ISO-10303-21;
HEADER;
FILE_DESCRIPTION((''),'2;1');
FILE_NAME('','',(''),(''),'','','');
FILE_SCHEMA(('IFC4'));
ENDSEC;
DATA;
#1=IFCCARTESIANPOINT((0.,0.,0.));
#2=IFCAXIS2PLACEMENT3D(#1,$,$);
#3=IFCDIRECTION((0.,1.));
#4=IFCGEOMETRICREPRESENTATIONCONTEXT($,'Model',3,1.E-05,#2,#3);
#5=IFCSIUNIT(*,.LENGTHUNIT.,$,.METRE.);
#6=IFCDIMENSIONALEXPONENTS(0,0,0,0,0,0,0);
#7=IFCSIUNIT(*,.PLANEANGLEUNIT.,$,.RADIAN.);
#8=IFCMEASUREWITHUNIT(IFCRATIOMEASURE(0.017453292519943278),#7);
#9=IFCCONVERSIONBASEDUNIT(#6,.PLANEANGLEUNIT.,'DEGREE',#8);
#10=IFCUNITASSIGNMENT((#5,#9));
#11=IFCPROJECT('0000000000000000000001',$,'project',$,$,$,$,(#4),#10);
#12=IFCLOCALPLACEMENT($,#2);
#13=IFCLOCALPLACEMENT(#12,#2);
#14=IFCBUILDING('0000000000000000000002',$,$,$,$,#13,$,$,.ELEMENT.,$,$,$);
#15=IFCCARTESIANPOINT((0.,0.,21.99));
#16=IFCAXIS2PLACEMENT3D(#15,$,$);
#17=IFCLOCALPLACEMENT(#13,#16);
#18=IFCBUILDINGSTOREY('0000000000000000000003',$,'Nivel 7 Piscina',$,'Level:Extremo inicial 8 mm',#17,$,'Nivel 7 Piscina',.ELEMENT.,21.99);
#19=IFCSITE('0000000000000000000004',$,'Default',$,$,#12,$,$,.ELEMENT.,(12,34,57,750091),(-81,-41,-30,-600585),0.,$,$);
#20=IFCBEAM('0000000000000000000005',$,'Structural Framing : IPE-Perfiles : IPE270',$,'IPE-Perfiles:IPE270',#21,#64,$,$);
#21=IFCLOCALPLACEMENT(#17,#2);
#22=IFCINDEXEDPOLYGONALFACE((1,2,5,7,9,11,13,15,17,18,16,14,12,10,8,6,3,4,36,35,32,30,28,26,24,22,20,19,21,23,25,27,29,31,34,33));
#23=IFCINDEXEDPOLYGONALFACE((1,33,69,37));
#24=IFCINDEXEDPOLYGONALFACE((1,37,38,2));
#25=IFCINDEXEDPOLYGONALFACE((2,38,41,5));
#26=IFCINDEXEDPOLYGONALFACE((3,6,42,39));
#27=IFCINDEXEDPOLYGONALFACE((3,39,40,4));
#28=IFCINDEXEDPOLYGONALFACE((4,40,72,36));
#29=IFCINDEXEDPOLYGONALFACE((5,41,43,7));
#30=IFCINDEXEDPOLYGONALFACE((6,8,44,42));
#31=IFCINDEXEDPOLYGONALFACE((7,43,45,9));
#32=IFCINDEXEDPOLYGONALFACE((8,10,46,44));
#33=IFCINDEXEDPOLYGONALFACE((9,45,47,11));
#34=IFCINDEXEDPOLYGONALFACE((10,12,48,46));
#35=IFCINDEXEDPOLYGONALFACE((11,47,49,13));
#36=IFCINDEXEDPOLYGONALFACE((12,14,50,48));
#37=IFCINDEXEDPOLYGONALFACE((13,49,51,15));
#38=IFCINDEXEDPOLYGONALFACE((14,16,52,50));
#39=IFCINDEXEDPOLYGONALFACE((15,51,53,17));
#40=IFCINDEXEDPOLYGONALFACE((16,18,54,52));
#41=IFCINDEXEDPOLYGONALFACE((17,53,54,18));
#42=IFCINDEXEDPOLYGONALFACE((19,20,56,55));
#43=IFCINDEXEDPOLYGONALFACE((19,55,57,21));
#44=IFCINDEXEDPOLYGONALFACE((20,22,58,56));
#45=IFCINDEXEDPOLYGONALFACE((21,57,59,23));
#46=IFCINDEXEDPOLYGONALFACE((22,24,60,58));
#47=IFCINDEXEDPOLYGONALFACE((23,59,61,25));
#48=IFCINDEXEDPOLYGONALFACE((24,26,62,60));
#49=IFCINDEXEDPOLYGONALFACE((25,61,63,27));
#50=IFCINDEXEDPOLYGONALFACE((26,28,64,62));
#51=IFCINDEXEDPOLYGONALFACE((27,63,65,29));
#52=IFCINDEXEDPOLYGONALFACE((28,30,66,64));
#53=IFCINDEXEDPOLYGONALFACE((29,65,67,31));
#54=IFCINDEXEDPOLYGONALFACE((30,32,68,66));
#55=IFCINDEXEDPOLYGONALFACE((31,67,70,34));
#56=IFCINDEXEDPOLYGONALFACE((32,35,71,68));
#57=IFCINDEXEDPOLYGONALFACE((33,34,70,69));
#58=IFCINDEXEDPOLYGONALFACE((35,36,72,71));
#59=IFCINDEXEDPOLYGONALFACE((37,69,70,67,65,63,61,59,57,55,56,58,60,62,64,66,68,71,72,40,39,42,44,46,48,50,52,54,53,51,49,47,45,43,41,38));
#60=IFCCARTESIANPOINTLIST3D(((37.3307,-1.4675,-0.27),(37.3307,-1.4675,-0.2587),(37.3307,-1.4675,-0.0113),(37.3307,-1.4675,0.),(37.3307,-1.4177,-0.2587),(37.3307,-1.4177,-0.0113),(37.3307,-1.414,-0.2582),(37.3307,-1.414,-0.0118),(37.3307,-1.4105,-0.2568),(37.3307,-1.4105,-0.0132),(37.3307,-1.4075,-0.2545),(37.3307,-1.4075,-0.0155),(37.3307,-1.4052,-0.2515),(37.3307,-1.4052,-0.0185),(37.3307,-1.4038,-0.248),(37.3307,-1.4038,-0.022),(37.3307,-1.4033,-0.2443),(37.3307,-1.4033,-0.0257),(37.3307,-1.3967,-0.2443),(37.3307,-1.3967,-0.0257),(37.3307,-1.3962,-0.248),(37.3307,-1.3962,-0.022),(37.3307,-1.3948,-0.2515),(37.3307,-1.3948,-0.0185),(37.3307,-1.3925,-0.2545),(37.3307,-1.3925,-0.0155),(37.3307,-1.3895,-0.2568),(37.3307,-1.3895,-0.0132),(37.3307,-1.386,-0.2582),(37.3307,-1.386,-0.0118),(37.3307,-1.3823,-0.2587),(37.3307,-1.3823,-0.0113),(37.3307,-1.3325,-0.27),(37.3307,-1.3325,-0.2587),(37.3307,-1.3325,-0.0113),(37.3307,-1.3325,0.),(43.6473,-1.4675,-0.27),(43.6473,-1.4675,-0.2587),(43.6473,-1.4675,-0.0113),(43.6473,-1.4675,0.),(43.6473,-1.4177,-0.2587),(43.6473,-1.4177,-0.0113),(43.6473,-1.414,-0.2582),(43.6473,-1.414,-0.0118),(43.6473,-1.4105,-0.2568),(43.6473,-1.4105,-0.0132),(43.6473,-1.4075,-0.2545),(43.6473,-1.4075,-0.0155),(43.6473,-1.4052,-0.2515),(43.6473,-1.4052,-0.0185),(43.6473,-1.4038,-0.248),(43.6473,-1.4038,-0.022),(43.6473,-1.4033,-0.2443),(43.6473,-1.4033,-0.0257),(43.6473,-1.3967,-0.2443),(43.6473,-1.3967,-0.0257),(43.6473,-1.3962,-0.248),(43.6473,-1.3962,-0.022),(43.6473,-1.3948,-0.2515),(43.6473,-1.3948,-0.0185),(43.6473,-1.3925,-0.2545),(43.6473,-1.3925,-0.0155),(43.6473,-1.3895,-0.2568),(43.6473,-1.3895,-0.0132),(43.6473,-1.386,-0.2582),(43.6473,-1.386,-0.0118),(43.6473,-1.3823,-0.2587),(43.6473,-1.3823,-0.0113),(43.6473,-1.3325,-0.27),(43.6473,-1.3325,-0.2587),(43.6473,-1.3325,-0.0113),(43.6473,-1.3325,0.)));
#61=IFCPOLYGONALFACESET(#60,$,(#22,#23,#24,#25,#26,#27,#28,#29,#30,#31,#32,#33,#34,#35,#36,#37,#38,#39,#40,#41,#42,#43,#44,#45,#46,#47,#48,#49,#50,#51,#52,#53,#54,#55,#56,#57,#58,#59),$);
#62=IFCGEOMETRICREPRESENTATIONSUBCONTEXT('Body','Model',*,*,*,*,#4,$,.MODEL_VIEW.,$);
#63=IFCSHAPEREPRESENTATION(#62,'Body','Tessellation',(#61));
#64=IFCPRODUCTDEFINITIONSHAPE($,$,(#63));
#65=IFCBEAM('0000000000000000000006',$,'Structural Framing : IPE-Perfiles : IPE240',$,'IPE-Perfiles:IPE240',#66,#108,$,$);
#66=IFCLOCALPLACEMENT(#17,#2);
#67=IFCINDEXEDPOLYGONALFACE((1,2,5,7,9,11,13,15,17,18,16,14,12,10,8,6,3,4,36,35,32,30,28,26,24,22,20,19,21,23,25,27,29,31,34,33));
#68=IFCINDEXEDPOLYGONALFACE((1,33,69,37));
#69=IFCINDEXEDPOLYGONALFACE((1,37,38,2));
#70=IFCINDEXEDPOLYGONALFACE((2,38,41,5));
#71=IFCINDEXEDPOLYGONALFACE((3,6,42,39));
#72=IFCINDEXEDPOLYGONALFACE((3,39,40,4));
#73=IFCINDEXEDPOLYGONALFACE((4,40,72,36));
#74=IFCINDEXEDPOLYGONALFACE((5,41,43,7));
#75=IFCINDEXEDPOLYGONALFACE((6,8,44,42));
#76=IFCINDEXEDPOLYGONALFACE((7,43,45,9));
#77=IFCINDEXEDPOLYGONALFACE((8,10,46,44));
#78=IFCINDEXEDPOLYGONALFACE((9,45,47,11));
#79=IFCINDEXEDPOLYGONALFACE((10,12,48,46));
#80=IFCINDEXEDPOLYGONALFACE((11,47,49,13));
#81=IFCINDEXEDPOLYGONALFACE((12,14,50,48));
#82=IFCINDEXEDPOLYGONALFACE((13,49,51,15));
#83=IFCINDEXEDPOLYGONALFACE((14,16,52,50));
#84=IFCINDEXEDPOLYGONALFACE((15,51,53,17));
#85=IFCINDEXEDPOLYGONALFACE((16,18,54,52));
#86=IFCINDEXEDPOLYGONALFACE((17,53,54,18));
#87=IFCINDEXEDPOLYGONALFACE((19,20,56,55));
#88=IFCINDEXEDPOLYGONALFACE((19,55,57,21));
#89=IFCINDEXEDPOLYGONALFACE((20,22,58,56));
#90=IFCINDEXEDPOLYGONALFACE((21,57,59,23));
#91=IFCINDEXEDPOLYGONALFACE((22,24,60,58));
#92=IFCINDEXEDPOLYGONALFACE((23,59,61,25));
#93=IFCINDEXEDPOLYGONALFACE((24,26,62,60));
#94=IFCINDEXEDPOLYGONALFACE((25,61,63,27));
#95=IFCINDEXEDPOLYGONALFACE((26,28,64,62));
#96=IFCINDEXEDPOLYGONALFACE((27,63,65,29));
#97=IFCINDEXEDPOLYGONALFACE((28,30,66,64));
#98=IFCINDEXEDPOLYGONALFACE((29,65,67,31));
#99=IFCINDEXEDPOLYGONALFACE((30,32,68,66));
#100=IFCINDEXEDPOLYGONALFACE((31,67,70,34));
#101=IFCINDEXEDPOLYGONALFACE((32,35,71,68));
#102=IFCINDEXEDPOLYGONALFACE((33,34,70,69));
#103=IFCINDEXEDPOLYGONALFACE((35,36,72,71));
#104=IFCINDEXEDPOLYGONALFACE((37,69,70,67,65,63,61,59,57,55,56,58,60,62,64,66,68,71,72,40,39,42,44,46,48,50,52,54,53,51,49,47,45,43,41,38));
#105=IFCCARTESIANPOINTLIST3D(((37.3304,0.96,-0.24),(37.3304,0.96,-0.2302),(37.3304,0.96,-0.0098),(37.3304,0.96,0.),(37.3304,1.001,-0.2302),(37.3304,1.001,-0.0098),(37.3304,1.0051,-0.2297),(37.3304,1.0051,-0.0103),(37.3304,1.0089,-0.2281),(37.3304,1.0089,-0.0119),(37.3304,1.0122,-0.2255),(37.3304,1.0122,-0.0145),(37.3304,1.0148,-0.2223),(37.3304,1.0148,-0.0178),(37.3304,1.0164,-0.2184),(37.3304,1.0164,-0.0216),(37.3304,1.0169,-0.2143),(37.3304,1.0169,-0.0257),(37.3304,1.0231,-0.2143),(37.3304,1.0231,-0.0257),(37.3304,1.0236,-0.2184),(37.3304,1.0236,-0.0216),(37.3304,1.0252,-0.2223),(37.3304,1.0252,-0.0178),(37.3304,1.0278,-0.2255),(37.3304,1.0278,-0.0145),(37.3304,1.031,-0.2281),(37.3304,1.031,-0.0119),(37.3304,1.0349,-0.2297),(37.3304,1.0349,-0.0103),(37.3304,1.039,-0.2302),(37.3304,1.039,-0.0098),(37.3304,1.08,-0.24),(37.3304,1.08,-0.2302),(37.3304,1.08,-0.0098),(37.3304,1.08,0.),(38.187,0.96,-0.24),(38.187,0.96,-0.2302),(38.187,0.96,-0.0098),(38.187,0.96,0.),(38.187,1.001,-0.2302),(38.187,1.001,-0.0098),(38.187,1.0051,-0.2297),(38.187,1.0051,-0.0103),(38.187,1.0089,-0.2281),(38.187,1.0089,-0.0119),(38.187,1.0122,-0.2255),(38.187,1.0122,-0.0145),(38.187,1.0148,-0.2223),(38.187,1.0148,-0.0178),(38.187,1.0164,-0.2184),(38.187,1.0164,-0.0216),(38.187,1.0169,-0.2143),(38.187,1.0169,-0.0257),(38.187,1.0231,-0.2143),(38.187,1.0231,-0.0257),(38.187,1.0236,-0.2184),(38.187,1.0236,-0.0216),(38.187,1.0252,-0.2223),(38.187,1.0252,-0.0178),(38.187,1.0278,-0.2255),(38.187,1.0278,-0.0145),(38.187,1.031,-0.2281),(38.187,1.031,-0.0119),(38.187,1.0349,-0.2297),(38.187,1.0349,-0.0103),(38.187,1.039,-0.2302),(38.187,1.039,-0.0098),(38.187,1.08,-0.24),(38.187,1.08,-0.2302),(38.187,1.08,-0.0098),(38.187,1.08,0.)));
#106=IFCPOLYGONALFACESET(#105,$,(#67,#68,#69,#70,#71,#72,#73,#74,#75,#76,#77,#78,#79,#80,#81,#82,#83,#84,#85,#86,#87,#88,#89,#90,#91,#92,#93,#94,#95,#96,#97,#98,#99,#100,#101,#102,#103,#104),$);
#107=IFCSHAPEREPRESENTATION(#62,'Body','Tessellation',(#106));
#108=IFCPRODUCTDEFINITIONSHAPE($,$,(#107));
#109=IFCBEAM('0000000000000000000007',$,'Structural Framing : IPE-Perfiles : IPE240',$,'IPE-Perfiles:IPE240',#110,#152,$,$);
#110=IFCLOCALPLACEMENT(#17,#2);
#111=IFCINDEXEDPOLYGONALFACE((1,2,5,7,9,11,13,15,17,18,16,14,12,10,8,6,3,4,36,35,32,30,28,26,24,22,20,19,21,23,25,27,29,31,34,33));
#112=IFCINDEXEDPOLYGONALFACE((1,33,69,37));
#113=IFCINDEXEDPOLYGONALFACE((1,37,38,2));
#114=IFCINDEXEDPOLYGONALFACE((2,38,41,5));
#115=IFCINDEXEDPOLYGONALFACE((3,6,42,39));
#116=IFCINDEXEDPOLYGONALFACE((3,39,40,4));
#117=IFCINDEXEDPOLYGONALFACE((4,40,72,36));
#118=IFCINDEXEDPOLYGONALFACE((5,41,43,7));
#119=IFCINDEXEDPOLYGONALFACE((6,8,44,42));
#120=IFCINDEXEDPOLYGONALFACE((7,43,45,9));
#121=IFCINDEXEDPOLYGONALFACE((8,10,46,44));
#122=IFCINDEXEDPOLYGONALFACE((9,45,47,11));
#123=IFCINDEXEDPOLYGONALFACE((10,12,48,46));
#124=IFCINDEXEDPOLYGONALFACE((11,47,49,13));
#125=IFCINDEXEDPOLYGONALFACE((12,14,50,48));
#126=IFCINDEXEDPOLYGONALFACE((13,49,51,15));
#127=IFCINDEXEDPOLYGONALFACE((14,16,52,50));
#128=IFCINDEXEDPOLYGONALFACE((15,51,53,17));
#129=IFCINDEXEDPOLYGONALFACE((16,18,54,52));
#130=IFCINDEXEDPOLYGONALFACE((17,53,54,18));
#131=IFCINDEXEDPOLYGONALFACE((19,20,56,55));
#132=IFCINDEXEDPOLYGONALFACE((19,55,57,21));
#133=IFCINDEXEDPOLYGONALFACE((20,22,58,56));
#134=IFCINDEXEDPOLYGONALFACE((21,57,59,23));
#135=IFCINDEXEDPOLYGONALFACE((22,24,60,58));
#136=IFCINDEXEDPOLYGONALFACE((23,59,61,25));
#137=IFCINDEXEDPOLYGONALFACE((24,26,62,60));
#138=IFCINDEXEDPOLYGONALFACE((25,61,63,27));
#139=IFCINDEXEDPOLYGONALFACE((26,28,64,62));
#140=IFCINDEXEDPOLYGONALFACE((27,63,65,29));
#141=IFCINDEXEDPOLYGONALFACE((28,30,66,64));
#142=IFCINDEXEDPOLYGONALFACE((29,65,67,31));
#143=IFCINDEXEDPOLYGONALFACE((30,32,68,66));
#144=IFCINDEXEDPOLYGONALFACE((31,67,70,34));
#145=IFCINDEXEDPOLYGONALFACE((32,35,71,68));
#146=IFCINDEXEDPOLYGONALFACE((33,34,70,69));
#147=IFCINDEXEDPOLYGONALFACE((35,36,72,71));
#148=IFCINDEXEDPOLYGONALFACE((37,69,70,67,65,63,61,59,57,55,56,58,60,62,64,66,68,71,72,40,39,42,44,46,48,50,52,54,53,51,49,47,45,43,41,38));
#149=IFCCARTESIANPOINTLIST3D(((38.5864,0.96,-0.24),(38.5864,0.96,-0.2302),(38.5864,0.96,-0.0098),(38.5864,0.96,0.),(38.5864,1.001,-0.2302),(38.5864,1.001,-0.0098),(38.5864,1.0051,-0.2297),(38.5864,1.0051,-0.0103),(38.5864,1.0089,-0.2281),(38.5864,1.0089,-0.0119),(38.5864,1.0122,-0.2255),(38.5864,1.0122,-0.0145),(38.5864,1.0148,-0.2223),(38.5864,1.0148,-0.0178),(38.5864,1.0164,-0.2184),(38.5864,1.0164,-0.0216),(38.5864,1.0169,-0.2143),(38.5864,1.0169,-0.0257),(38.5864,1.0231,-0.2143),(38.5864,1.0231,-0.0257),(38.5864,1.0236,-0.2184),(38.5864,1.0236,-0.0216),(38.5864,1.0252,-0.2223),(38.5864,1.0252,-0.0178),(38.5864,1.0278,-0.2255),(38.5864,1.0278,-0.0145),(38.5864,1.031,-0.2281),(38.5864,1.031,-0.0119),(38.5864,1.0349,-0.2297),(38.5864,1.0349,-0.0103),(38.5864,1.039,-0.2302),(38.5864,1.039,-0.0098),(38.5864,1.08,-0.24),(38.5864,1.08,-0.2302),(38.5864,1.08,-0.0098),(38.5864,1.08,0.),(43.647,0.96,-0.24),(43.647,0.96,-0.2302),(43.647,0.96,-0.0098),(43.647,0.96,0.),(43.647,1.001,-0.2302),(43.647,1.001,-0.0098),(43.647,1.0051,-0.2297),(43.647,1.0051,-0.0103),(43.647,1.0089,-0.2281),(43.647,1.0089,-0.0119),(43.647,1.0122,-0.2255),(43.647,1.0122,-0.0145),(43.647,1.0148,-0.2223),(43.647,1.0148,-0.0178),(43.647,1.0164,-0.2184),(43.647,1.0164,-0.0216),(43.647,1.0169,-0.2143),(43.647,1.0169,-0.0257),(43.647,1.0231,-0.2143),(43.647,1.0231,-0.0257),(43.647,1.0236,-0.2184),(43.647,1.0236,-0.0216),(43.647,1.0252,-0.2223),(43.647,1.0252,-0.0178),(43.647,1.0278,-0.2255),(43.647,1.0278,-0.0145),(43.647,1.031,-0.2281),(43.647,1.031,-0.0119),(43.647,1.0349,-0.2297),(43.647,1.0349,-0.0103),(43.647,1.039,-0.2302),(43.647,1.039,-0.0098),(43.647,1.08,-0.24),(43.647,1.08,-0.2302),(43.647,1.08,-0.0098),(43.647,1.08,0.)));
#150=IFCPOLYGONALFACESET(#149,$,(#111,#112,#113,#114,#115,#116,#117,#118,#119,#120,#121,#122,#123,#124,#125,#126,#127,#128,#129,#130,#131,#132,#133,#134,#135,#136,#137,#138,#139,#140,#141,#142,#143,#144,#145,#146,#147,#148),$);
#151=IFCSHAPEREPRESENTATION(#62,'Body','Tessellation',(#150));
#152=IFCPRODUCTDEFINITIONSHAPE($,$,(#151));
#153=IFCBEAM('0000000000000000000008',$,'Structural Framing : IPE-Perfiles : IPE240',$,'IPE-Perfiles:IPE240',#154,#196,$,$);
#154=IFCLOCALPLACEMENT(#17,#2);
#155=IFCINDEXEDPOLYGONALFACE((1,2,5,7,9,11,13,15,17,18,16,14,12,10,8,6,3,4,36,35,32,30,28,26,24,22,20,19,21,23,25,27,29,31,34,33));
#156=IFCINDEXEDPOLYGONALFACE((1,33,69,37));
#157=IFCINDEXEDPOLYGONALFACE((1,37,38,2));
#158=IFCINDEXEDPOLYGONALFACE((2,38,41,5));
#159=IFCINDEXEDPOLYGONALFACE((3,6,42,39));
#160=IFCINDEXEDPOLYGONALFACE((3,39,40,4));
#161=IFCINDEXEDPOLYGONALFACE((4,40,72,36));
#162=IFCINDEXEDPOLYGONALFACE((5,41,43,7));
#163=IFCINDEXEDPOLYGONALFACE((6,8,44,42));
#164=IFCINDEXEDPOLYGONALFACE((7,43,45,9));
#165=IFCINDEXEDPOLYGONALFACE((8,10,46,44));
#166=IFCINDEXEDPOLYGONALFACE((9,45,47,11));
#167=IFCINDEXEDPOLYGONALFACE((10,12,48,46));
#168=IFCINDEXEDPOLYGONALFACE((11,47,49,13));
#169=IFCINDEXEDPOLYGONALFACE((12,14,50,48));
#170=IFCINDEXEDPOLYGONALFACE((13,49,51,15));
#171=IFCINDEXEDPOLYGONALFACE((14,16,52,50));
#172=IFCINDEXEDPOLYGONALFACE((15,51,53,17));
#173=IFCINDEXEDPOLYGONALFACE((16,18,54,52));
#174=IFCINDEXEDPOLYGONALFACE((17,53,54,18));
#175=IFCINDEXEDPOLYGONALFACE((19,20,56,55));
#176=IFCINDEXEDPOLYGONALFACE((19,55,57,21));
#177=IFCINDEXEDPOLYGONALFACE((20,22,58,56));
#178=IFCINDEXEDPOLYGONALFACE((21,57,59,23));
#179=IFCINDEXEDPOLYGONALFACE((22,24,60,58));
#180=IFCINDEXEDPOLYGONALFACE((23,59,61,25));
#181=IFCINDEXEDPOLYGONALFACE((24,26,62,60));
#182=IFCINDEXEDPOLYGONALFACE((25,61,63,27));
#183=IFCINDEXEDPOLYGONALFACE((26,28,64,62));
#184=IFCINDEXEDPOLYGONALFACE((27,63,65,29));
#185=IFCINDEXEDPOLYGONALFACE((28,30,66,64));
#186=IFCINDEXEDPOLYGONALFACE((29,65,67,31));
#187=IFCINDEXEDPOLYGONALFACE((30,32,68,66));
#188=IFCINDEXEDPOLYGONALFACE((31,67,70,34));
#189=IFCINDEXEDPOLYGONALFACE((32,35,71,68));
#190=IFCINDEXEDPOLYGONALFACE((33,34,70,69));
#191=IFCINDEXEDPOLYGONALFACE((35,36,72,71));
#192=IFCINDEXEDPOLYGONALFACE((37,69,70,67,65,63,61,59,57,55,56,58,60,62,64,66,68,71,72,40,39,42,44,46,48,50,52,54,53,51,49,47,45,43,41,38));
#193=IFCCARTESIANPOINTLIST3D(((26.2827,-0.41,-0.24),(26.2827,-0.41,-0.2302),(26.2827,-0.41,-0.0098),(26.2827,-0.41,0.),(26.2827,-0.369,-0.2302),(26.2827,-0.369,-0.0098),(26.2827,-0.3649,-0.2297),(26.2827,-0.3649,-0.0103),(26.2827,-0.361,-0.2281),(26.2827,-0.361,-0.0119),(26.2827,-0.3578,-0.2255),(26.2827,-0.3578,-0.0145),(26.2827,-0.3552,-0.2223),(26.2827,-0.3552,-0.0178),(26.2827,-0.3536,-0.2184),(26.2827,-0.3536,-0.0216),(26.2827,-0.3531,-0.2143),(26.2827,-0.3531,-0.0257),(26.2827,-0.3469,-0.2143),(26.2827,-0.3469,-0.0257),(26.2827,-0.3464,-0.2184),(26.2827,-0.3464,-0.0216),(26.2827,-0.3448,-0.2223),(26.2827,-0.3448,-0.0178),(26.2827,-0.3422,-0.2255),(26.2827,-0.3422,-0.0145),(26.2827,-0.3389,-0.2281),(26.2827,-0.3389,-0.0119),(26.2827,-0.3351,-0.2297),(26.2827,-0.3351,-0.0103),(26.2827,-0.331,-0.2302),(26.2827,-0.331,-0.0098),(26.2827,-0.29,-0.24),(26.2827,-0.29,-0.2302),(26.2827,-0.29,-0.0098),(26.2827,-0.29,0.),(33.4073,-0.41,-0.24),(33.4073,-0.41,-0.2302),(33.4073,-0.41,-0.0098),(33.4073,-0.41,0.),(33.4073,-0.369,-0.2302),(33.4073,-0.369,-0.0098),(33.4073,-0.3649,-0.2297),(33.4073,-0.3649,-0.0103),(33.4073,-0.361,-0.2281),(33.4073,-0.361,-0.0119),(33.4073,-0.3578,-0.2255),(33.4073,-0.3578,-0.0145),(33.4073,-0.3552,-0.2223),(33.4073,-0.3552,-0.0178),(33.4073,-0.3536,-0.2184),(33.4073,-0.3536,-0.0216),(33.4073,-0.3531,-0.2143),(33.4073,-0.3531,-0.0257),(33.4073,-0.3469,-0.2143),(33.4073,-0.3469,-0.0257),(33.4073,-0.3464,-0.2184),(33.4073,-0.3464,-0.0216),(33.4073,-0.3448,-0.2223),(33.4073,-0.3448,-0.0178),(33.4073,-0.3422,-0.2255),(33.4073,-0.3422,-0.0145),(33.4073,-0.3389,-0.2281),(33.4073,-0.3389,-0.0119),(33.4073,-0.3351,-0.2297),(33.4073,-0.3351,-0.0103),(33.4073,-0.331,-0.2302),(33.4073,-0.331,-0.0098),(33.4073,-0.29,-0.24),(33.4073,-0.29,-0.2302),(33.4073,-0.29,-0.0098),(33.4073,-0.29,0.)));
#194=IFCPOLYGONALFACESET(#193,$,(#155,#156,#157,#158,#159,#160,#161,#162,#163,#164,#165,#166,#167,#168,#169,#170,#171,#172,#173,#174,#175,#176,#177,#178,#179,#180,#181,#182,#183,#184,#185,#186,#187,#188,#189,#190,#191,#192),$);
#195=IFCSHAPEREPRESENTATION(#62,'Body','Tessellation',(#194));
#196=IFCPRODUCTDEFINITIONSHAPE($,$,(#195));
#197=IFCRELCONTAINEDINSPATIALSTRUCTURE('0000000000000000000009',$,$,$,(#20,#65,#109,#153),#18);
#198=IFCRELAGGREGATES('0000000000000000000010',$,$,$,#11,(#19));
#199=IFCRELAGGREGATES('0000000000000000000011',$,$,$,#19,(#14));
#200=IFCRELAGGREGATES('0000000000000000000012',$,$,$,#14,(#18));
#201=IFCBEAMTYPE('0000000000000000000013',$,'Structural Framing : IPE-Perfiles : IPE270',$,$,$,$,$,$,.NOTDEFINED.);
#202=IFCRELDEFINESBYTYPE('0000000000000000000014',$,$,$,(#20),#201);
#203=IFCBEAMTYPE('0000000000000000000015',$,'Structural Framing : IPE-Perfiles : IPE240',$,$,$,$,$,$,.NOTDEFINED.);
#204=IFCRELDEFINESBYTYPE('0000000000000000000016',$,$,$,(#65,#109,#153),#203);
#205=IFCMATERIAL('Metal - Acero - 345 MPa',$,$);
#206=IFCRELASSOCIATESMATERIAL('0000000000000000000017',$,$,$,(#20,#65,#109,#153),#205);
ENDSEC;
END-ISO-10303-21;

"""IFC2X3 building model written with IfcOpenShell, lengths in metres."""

from ifc_helpers import new_model, entity, si_unit, converted_unit, direction, frame, frame_2d, origin, place, context, subcontext, project, spatial, i_section, extrude, material, type_object, element, save


model = new_model("IFC2X3")

# Units and contexts
model_context = context("Model", 3, precision=1e-05, world=origin(), true_north=direction((0.0, 1.0)))
body_context = subcontext(model_context, "Body", "Model", "MODEL_VIEW")
ifc_project = project(units=[si_unit("LENGTHUNIT", "METRE"), converted_unit("PLANEANGLEUNIT", "DEGREE", entity("IfcRatioMeasure", 0.017453292519943278), si_unit("PLANEANGLEUNIT", "RADIAN"), dimensions=[0, 0, 0, 0, 0, 0, 0])], contexts=[model_context])

# Site, building, storey
site_placement = place(None, origin())
site = spatial("IfcSite", under=ifc_project, at=site_placement, Name="Default", CompositionType="ELEMENT", RefLatitude=(12, 34, 57, 750091), RefLongitude=(-81, -41, -30, -600585), RefElevation=0.0)
building_placement = place(site_placement, origin())
building = spatial("IfcBuilding", under=site, at=building_placement, CompositionType="ELEMENT")
storey_placement = place(building_placement, frame((0.0, 0.0, 21.99)))
storey = spatial("IfcBuildingStorey", under=building, at=storey_placement, Name="Nivel 7 Piscina", ObjectType="Level:Extremo inicial 8 mm", LongName="Nivel 7 Piscina", CompositionType="ELEMENT", Elevation=21.99)

# Shared definitions
ifc_material = material(Name="Metal - Acero - 345 MPa")

# Beams
beam_type_1 = type_object("IfcBeamType", Name="Structural Framing : IPE-Perfiles : IPE270", PredefinedType="NOTDEFINED")
beam_1_placement = place(storey_placement, frame((37.25, -1.4, 0.0)))
element("IfcBeam", 1, at=beam_1_placement, inside=storey, type_object=beam_type_1, material=ifc_material, Name="Structural Framing : IPE-Perfiles : IPE270", ObjectType="IPE-Perfiles:IPE270", context=body_context, shape_type="SweptSolid", body=[
    extrude(i_section(OverallWidth=0.135, OverallDepth=0.27, WebThickness=0.0066, FlangeThickness=0.0113, FilletRadius=0.0144, at=frame_2d((0.0, 0.0), x_axis=(0.0, 1.0))), frame((0.0807, 0.0, -0.135), z_axis=(1.0, 0.0, 0.0), x_axis=(0.0, 0.0, -1.0)), (0.0, 0.0, 1.0), 6.3166),
])
beam_type_2 = type_object("IfcBeamType", Name="Structural Framing : IPE-Perfiles : IPE240", PredefinedType="NOTDEFINED")
beam_2_placement = place(storey_placement, frame((37.25, 1.02, 0.0)))
element("IfcBeam", 2, at=beam_2_placement, inside=storey, type_object=beam_type_2, material=ifc_material, Name="Structural Framing : IPE-Perfiles : IPE240", ObjectType="IPE-Perfiles:IPE240", context=body_context, shape_type="SweptSolid", body=[
    extrude(i_section(OverallWidth=0.12, OverallDepth=0.24, WebThickness=0.0062, FlangeThickness=0.0098, FilletRadius=0.0159, at=frame_2d((0.0, 0.0), x_axis=(0.0, 1.0))), frame((0.0804, 0.0, -0.12), z_axis=(1.0, 0.0, 0.0), x_axis=(0.0, 0.0, -1.0)), (0.0, 0.0, 1.0), 0.8566),
])
beam_3_placement = place(storey_placement, frame((38.3844, 1.02, 0.0)))
element("IfcBeam", 3, at=beam_3_placement, inside=storey, type_object=beam_type_2, material=ifc_material, Name="Structural Framing : IPE-Perfiles : IPE240", ObjectType="IPE-Perfiles:IPE240", context=body_context, shape_type="SweptSolid", body=[
    extrude(i_section(OverallWidth=0.12, OverallDepth=0.24, WebThickness=0.0062, FlangeThickness=0.0098, FilletRadius=0.0159, at=frame_2d((0.0, 0.0), x_axis=(0.0, 1.0))), frame((0.202, 0.0, -0.12), z_axis=(1.0, 0.0, 0.0), x_axis=(0.0, 0.0, -1.0)), (0.0, 0.0, 1.0), 5.0606),
])
beam_4_placement = place(storey_placement, frame((26.195, -0.35, 0.0)))
element("IfcBeam", 4, at=beam_4_placement, inside=storey, type_object=beam_type_2, material=ifc_material, Name="Structural Framing : IPE-Perfiles : IPE240", ObjectType="IPE-Perfiles:IPE240", context=body_context, shape_type="SweptSolid", body=[
    extrude(i_section(OverallWidth=0.12, OverallDepth=0.24, WebThickness=0.0062, FlangeThickness=0.0098, FilletRadius=0.0159, at=frame_2d((0.0, 0.0), x_axis=(0.0, 1.0))), frame((0.0877, 0.0, -0.12), z_axis=(1.0, 0.0, 0.0), x_axis=(0.0, 0.0, -1.0)), (0.0, 0.0, 1.0), 7.1246),
])

save(model, "model.ifc")
